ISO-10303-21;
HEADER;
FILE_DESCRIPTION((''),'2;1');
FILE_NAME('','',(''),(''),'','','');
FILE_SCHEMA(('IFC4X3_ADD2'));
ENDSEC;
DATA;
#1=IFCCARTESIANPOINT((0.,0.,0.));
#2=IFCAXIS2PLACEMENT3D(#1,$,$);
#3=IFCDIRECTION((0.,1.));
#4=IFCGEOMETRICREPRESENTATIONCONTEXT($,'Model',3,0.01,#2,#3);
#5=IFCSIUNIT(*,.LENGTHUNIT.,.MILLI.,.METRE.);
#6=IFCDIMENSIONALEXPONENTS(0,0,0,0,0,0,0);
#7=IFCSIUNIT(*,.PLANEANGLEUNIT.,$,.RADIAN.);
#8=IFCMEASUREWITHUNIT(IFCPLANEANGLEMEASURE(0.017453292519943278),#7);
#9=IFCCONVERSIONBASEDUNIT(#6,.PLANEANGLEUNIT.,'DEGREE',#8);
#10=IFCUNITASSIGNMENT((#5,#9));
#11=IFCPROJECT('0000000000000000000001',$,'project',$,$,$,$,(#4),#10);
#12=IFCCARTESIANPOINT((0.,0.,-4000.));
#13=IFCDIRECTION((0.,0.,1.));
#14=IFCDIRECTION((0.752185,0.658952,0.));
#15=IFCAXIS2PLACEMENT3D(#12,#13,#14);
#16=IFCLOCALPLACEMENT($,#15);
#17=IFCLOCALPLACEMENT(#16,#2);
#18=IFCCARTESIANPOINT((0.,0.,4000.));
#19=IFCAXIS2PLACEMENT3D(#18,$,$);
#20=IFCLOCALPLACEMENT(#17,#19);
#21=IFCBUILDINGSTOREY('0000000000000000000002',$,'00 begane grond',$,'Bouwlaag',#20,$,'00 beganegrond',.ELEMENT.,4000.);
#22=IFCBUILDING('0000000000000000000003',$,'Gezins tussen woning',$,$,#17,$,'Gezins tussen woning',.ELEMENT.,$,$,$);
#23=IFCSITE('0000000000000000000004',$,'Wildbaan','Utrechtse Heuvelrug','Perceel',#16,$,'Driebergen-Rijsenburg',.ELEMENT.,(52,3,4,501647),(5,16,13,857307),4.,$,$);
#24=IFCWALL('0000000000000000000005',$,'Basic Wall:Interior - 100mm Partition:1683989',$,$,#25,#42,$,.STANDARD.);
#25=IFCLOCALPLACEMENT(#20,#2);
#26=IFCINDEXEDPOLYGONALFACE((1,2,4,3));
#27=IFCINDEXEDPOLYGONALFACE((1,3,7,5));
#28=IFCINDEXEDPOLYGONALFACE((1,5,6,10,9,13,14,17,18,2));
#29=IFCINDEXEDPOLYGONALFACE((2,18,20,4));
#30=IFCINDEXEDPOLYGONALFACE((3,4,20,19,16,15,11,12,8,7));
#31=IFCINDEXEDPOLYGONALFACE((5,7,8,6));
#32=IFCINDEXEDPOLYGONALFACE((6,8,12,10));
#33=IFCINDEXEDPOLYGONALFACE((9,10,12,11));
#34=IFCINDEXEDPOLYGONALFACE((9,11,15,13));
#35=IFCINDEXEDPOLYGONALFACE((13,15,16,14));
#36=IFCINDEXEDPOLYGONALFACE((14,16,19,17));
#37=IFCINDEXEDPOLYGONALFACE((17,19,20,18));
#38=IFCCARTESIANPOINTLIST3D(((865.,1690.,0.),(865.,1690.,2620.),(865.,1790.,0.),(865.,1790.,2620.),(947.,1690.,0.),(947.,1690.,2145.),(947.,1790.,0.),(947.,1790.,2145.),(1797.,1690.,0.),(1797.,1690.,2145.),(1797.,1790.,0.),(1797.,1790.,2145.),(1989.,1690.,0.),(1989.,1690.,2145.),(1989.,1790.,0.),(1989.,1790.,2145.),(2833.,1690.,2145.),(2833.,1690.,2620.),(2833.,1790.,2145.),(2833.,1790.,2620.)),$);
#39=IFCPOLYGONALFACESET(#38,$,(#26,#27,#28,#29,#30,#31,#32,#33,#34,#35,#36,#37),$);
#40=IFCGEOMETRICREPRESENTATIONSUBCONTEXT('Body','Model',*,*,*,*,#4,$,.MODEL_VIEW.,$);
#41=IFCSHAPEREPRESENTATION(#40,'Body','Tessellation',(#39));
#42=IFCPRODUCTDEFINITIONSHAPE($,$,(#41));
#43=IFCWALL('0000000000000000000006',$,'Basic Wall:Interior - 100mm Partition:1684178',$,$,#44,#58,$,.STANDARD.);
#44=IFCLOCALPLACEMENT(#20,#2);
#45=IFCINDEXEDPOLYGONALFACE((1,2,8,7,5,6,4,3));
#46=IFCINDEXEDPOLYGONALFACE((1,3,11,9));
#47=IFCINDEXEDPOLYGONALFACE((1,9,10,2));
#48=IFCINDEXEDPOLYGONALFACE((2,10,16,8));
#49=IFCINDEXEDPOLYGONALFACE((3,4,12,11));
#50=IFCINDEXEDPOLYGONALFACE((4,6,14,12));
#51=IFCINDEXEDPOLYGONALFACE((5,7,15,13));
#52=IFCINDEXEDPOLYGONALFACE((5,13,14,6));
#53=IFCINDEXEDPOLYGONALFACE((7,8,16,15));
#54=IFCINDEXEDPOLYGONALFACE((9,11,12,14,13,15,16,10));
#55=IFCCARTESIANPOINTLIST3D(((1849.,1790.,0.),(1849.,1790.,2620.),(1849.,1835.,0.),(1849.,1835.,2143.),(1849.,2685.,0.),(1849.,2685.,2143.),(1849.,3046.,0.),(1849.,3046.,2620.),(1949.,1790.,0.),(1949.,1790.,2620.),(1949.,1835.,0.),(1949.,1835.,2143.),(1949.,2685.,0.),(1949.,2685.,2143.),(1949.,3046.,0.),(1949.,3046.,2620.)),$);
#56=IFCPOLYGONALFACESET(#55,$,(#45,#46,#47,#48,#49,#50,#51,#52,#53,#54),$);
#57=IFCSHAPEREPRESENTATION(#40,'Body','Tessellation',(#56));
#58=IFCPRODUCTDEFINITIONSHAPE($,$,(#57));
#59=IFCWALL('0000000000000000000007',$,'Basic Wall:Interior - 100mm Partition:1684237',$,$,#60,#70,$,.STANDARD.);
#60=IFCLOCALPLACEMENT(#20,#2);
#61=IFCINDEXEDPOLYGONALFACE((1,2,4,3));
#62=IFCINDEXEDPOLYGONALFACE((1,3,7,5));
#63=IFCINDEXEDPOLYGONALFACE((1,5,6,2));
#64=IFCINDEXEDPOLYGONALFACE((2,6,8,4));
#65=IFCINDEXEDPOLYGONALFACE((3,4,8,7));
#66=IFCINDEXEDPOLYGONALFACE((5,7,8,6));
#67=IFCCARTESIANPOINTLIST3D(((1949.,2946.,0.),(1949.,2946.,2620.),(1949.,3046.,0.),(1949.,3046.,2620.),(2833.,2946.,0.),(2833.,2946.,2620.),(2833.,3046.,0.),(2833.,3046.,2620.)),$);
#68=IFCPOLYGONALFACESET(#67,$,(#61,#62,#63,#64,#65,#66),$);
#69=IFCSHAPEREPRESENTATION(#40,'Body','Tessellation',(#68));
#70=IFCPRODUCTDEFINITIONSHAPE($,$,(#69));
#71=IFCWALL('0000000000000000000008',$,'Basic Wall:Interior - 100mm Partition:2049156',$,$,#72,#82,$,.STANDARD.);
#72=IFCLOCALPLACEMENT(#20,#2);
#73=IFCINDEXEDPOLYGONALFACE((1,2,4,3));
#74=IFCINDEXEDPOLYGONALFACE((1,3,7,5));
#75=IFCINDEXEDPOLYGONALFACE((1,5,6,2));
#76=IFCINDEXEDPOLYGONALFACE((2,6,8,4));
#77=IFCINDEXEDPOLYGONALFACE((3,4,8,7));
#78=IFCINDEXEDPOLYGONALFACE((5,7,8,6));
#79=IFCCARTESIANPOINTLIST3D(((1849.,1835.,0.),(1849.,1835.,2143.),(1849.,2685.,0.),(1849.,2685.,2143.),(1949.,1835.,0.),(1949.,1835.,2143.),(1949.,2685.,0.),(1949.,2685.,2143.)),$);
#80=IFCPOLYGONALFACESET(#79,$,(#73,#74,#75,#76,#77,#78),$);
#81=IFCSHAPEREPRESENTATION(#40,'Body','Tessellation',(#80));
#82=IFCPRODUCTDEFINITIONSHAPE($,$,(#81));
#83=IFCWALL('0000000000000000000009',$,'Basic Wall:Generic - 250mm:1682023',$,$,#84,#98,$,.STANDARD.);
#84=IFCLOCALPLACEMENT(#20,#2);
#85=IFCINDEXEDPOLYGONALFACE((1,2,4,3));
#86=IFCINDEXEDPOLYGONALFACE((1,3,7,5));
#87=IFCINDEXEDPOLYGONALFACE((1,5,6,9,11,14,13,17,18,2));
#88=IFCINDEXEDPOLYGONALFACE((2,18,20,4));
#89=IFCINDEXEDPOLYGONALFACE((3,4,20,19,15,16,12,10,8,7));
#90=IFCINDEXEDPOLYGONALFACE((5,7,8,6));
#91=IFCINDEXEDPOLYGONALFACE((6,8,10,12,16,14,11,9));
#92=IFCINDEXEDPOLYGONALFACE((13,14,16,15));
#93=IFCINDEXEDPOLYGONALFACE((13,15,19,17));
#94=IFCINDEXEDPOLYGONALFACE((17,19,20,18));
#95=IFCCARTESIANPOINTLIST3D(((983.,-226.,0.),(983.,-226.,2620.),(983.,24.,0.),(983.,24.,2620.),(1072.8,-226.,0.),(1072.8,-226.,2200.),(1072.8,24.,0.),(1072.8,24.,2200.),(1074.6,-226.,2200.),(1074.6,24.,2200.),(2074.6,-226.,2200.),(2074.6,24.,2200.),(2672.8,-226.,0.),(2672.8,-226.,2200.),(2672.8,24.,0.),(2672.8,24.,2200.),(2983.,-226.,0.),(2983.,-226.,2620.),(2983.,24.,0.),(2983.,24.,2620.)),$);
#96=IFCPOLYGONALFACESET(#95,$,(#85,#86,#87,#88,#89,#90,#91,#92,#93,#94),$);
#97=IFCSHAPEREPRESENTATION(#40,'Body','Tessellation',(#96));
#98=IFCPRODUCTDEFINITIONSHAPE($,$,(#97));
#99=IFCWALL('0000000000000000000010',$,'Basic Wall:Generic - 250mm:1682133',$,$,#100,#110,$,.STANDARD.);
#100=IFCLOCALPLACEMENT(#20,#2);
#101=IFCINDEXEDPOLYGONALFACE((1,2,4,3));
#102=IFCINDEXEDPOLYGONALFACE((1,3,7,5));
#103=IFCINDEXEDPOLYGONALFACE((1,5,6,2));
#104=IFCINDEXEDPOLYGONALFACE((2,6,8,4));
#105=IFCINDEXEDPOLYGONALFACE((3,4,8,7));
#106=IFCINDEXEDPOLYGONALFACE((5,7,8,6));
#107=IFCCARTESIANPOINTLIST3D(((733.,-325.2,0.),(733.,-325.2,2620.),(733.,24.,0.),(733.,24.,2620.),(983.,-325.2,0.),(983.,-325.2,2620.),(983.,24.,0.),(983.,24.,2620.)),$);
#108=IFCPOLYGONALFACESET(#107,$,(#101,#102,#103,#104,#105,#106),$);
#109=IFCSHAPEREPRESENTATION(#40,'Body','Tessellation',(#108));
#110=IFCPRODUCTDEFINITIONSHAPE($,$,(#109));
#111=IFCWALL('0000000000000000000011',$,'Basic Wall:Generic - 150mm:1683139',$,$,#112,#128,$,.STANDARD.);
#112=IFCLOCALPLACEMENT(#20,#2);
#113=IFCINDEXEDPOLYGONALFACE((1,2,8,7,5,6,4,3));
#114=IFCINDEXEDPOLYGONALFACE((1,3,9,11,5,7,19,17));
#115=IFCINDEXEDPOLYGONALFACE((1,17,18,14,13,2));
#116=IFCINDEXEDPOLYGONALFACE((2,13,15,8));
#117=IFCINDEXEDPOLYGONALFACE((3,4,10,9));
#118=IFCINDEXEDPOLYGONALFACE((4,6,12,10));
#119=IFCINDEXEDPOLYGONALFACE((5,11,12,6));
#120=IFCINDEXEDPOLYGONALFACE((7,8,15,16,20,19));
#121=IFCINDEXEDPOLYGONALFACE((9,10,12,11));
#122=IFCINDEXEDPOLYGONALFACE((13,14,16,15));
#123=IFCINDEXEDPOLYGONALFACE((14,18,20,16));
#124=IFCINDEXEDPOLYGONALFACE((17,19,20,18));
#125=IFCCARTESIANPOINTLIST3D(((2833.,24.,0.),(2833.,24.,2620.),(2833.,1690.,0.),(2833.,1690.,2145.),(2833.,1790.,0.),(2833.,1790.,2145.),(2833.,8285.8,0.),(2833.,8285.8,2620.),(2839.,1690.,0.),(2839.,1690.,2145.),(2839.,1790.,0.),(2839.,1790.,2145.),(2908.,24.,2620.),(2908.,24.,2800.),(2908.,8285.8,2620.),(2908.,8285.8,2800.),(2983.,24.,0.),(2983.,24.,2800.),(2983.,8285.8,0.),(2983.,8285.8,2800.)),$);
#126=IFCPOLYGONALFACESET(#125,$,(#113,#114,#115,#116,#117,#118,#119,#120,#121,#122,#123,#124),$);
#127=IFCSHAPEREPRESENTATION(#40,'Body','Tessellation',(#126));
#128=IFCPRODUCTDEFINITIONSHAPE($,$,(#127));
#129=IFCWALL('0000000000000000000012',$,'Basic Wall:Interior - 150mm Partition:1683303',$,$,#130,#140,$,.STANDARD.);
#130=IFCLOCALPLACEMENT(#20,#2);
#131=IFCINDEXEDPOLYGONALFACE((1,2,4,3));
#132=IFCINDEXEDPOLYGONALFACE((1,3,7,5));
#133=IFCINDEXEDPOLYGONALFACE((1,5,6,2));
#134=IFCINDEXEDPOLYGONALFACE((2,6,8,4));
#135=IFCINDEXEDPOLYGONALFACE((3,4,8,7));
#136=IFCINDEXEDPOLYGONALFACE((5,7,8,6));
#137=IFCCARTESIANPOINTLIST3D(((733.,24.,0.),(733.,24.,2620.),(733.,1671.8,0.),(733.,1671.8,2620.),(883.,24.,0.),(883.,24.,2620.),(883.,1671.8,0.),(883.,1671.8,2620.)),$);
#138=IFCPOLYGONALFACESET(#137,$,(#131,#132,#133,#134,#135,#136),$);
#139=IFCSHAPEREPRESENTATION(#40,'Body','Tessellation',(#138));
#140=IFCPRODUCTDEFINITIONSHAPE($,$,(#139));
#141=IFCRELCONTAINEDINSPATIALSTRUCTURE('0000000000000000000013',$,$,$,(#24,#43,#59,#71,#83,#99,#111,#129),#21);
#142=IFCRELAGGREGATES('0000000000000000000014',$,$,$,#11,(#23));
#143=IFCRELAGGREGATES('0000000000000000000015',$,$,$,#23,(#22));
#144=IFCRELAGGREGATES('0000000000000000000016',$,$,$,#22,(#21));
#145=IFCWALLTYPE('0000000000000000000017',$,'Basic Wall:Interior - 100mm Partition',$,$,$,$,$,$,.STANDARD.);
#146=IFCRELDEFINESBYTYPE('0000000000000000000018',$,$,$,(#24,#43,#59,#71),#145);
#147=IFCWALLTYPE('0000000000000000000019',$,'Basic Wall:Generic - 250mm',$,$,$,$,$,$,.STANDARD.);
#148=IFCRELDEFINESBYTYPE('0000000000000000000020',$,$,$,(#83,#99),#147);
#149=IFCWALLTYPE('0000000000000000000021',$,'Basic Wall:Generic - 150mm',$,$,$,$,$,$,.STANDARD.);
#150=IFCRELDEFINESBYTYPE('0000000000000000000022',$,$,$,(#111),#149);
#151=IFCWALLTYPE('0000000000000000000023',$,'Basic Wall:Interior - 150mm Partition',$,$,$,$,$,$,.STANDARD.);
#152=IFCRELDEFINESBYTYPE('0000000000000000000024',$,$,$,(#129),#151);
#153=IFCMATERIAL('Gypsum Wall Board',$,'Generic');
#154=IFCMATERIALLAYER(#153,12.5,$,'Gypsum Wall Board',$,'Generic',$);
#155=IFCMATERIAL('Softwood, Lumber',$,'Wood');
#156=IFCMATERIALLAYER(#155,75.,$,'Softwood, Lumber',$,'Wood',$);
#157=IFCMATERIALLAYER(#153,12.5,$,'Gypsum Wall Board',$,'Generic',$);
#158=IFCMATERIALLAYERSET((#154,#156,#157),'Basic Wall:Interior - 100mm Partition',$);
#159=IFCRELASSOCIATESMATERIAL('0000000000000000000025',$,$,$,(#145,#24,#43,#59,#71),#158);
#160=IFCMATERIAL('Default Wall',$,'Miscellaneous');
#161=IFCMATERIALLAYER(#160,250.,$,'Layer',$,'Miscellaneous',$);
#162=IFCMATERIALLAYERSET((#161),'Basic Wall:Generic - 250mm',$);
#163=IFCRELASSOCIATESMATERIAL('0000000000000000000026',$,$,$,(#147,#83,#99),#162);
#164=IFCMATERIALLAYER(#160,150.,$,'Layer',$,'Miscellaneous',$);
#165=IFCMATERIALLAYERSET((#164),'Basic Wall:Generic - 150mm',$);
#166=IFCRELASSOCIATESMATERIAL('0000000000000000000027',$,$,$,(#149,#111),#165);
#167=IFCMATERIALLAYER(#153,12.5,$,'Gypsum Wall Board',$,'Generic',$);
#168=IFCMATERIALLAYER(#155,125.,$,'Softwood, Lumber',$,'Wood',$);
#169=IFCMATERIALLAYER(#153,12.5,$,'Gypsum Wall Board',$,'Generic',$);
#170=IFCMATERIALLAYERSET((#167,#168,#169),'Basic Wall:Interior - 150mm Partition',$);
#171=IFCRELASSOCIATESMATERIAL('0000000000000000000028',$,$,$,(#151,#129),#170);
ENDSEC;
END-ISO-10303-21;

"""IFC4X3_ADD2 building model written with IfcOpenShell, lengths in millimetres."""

from ifc_helpers import new_model, entity, si_unit, converted_unit, direction, frame, frame_2d, origin, place, context, subcontext, project, spatial, polyline, rectangle, extrude, clip, bounded_halfspace, material, layer, layer_set, type_object, element, save


model = new_model("IFC4X3_ADD2")

# Units and contexts
model_context = context("Model", 3, precision=0.01, world=origin(), true_north=direction((0.0, 1.0)))
body_context = subcontext(model_context, "Body", "Model", "MODEL_VIEW")
ifc_project = project(units=[si_unit("LENGTHUNIT", "METRE", prefix="MILLI"), converted_unit("PLANEANGLEUNIT", "DEGREE", entity("IfcPlaneAngleMeasure", 0.017453292519943278), si_unit("PLANEANGLEUNIT", "RADIAN"), dimensions=[0, 0, 0, 0, 0, 0, 0])], contexts=[model_context])

# Site, building, storey
site_placement = place(None, frame((0.0, 0.0, -4000.0), z_axis=(0.0, 0.0, 1.0), x_axis=(0.752185, 0.658952, 0.0)))
site = spatial("IfcSite", under=ifc_project, at=site_placement, Name="Wildbaan", Description="Utrechtse Heuvelrug", ObjectType="Perceel", LongName="Driebergen-Rijsenburg", CompositionType="ELEMENT", RefLatitude=(52, 3, 4, 501647), RefLongitude=(5, 16, 13, 857307), RefElevation=4.0)
building_placement = place(site_placement, origin())
building = spatial("IfcBuilding", under=site, at=building_placement, Name="Gezins tussen woning", LongName="Gezins tussen woning", CompositionType="ELEMENT")
storey_placement = place(building_placement, frame((0.0, 0.0, 4000.0)))
storey = spatial("IfcBuildingStorey", under=building, at=storey_placement, Name="00 begane grond", ObjectType="Bouwlaag", LongName="00 beganegrond", CompositionType="ELEMENT", Elevation=4000.0)

# Shared definitions
ifc_material_1 = material(Name="Gypsum Wall Board", Category="Generic")
ifc_layer_1 = layer(ifc_material_1, 12.5, Name="Gypsum Wall Board", Category="Generic")
ifc_material_2 = material(Name="Softwood, Lumber", Category="Wood")
ifc_layer_2 = layer(ifc_material_2, 75.0, Name="Softwood, Lumber", Category="Wood")
ifc_layer_3 = layer(ifc_material_1, 12.5, Name="Gypsum Wall Board", Category="Generic")
ifc_layer_set_1 = layer_set([ifc_layer_1, ifc_layer_2, ifc_layer_3], Name="Basic Wall:Interior - 100mm Partition")
wall_type_1 = type_object("IfcWallType", Name="Basic Wall:Interior - 100mm Partition", PredefinedType="STANDARD", material=ifc_layer_set_1)

# Wall, openings
wall_1_placement = place(storey_placement, frame((2833.0, 1740.0, 0.0), z_axis=(0.0, 0.0, 1.0), x_axis=(-1.0, 0.0, 0.0)))
wall_1 = element("IfcWall", 1, at=wall_1_placement, inside=storey, type_object=wall_type_1, material=ifc_layer_set_1, Name="Basic Wall:Interior - 100mm Partition:1683989", PredefinedType="STANDARD", context=body_context, shape_type="Clipping", body=[
    clip(extrude(rectangle(XDim=1968.0, YDim=100.0, at=frame_2d((984.0, 0.0), x_axis=(-1.0, 0.0))), origin(), (0.0, 0.0, 1.0), 2620.0), bounded_halfspace(frame((0.0, -50.0, 2620.0), z_axis=(0.0, 0.0, -1.0), x_axis=(0.0, 1.0, 0.0)), True, frame((0.0, -50.0, 2620.0)), polyline([(0.0, 0.0), (884.0, 0.0), (984.0, 0.0), (1968.0, 0.0), (1968.0, 100.0), (0.0, 100.0), (0.0, 0.0)]))),
])
opening_1_placement = place(wall_1_placement, frame((2833.0, 1740.0, 0.0), z_axis=(0.0, 0.0, 1.0), x_axis=(-1.0, 0.0, 0.0)))
element("IfcOpeningElement", 2, at=opening_1_placement, cuts=wall_1, PredefinedType="OPENING", context=body_context, shape_type="SweptSolid", body=[
    extrude(rectangle(XDim=2145.0, YDim=850.0, at=frame_2d((0.0, 0.0), x_axis=(1.0, 0.0))), frame((1372.0, 1790.0, 1072.5), z_axis=(0.0, -1.0, 0.0), x_axis=(0.0, 0.0, -1.0)), (0.0, 0.0, 1.0), 100.0),
])
opening_2_placement = place(wall_1_placement, frame((2833.0, 1740.0, 0.0), z_axis=(0.0, 0.0, 1.0), x_axis=(-1.0, 0.0, 0.0)))
element("IfcOpeningElement", 3, at=opening_2_placement, cuts=wall_1, PredefinedType="OPENING", context=body_context, shape_type="SweptSolid", body=[
    extrude(rectangle(XDim=2145.0, YDim=850.0, at=frame_2d((0.0, 0.0), x_axis=(0.0, 1.0))), frame((2414.0, 1790.0, 1072.5), z_axis=(0.0, -1.0, 0.0), x_axis=(-1.0, 0.0, 0.0)), (0.0, 0.0, 1.0), 100.0),
])

# Wall, opening
wall_2_placement = place(storey_placement, frame((1899.0, 1790.0, 0.0), z_axis=(0.0, 0.0, 1.0), x_axis=(0.0, 1.0, 0.0)))
wall_2 = element("IfcWall", 4, at=wall_2_placement, inside=storey, type_object=wall_type_1, material=ifc_layer_set_1, Name="Basic Wall:Interior - 100mm Partition:1684178", PredefinedType="STANDARD", context=body_context, shape_type="Clipping", body=[
    clip(extrude(rectangle(XDim=1256.0, YDim=100.0, at=frame_2d((628.0, 0.0), x_axis=(1.0, 0.0))), origin(), (0.0, 0.0, 1.0), 2620.0), bounded_halfspace(frame((0.0, -50.0, 2620.0), z_axis=(0.0, 0.0, -1.0), x_axis=(-1.0, 0.0, 0.0)), True, frame((0.0, -50.0, 2620.0)), polyline([(0.0, 0.0), (1156.0, 0.0), (1256.0, 0.0), (1256.0, 100.0), (0.0, 100.0), (0.0, 0.0)]))),
])
opening_3_placement = place(wall_2_placement, frame((-1790.0, 1899.0, -2.0), z_axis=(0.0, 0.0, 1.0), x_axis=(0.0, -1.0, 0.0)))
element("IfcOpeningElement", 5, at=opening_3_placement, cuts=wall_2, PredefinedType="OPENING", context=body_context, shape_type="SweptSolid", body=[
    extrude(rectangle(XDim=2145.0, YDim=850.0, at=frame_2d((0.0, 0.0), x_axis=(0.0, 1.0))), frame((1949.0, 2260.0, 1072.5), z_axis=(-1.0, 0.0, 0.0), x_axis=(0.0, 1.0, 0.0)), (0.0, 0.0, 1.0), 100.0),
])

# Walls
wall_3_placement = place(storey_placement, frame((1949.0, 2996.0, 0.0)))
element("IfcWall", 6, at=wall_3_placement, inside=storey, type_object=wall_type_1, material=ifc_layer_set_1, Name="Basic Wall:Interior - 100mm Partition:1684237", PredefinedType="STANDARD", context=body_context, shape_type="Clipping", body=[
    clip(extrude(rectangle(XDim=884.0, YDim=100.0, at=frame_2d((442.0, 0.0), x_axis=(-1.0, 0.0))), origin(), (0.0, 0.0, 1.0), 2620.0), bounded_halfspace(frame((0.0, -50.0, 2620.0), z_axis=(0.0, 0.0, -1.0), x_axis=(0.0, -1.0, 0.0)), True, frame((0.0, -50.0, 2620.0)), polyline([(0.0, 0.0), (654.0, 0.0), (754.0, 0.0), (884.0, 0.0), (884.0, 100.0), (0.0, 100.0), (0.0, 0.0)]))),
])
wall_4_placement = place(storey_placement, frame((1899.0, 1835.0, 0.0), z_axis=(0.0, 0.0, 1.0), x_axis=(0.0, 1.0, 0.0)))
element("IfcWall", 7, at=wall_4_placement, inside=storey, type_object=wall_type_1, material=ifc_layer_set_1, Name="Basic Wall:Interior - 100mm Partition:2049156", PredefinedType="STANDARD", context=body_context, shape_type="SweptSolid", body=[
    extrude(rectangle(XDim=850.0, YDim=100.0, at=frame_2d((425.0, 0.0), x_axis=(-1.0, 0.0))), origin(), (0.0, 0.0, 1.0), 2143.0),
])

# Wall, openings
ifc_material_3 = material(Name="Default Wall", Category="Miscellaneous")
ifc_layer_4 = layer(ifc_material_3, 250.0, Name="Layer", Category="Miscellaneous")
ifc_layer_set_2 = layer_set([ifc_layer_4], Name="Basic Wall:Generic - 250mm")
wall_type_2 = type_object("IfcWallType", Name="Basic Wall:Generic - 250mm", PredefinedType="STANDARD", material=ifc_layer_set_2)
wall_5_placement = place(storey_placement, frame((983.0, -101.0, 0.0)))
wall_5 = element("IfcWall", 8, at=wall_5_placement, inside=storey, type_object=wall_type_2, material=ifc_layer_set_2, Name="Basic Wall:Generic - 250mm:1682023", PredefinedType="STANDARD", context=body_context, shape_type="SweptSolid", body=[
    extrude(rectangle(XDim=2000.0, YDim=250.0, at=frame_2d((1000.0, 0.0), x_axis=(-1.0, 0.0))), origin(), (0.0, 0.0, 1.0), 2620.0),
])
opening_4_placement = place(wall_5_placement, frame((91.6, -125.0, 0.0)))
element("IfcOpeningElement", 9, at=opening_4_placement, cuts=wall_5, PredefinedType="OPENING", context=body_context, shape_type="SweptSolid", body=[
    extrude(rectangle(XDim=2200.0, YDim=1000.0, at=frame_2d((1100.0, 500.0), x_axis=(1.0, 0.0))), frame((0.0, 0.0, 0.0), z_axis=(0.0, 1.0, 0.0), x_axis=(0.0, 0.0, 1.0)), (0.0, 0.0, 1.0), 250.0),
])
opening_5_placement = place(wall_5_placement, frame((-983.0, 101.0, 0.0)))
element("IfcOpeningElement", 10, at=opening_5_placement, cuts=wall_5, PredefinedType="OPENING", context=body_context, shape_type="SweptSolid", body=[
    extrude(rectangle(XDim=2200.0, YDim=1600.0, at=frame_2d((0.0, 0.0), x_axis=(1.0, 0.0))), frame((1872.8, -226.0, 1100.0), z_axis=(0.0, 1.0, 0.0), x_axis=(0.0, 0.0, -1.0)), (0.0, 0.0, 1.0), 250.0),
])

# Wall
wall_6_placement = place(storey_placement, frame((858.0, -325.2, 0.0), z_axis=(0.0, 0.0, 1.0), x_axis=(0.0, 1.0, 0.0)))
element("IfcWall", 11, at=wall_6_placement, inside=storey, type_object=wall_type_2, material=ifc_layer_set_2, Name="Basic Wall:Generic - 250mm:1682133", PredefinedType="STANDARD", context=body_context, shape_type="Clipping", body=[
    clip(extrude(rectangle(XDim=349.2, YDim=250.0, at=frame_2d((174.6, 0.0), x_axis=(-1.0, 0.0))), origin(), (0.0, 0.0, 1.0), 2620.0), bounded_halfspace(frame((0.0, -125.0, 2620.0), z_axis=(0.0, 0.0, -1.0), x_axis=(-1.0, 0.0, 0.0)), True, frame((0.0, -125.0, 2620.0)), polyline([(0.0, 0.0), (99.2, 0.0), (349.2, 0.0), (349.2, 200.0), (0.0, 200.0), (0.0, 0.0)]))),
])

# Wall, opening
ifc_layer_5 = layer(ifc_material_3, 150.0, Name="Layer", Category="Miscellaneous")
ifc_layer_set_3 = layer_set([ifc_layer_5], Name="Basic Wall:Generic - 150mm")
wall_type_3 = type_object("IfcWallType", Name="Basic Wall:Generic - 150mm", PredefinedType="STANDARD", material=ifc_layer_set_3)
wall_7_placement = place(storey_placement, frame((2908.0, 24.0, 0.0), z_axis=(0.0, 0.0, 1.0), x_axis=(0.0, 1.0, 0.0)))
wall_7 = element("IfcWall", 12, at=wall_7_placement, inside=storey, type_object=wall_type_3, material=ifc_layer_set_3, Name="Basic Wall:Generic - 150mm:1683139", PredefinedType="STANDARD", context=body_context, shape_type="Clipping", body=[
    clip(extrude(rectangle(XDim=8261.8, YDim=150.0, at=frame_2d((4130.9, 0.0), x_axis=(-1.0, 0.0))), origin(), (0.0, 0.0, 1.0), 2800.0), bounded_halfspace(frame((8261.8, 75.0, 2620.0), z_axis=(0.0, 0.0, -1.0), x_axis=(-1.0, 0.0, 0.0)), True, frame((8261.8, 75.0, 2620.0)), polyline([(0.0, 0.0), (-8261.8, 0.0), (-8261.8, -75.0), (0.0, -75.0), (0.0, 0.0)]))),
])
opening_6_placement = place(wall_7_placement, frame((-24.0, 2908.0, 0.0)))
element("IfcOpeningElement", 13, at=opening_6_placement, cuts=wall_7, PredefinedType="OPENING", context=body_context, shape_type="SweptSolid", body=[
    extrude(rectangle(XDim=2145.0, YDim=100.0, at=frame_2d((0.0, 0.0), x_axis=(0.0, 1.0))), frame((1740.0, -2839.0, 1072.5), z_axis=(0.0, 1.0, 0.0), x_axis=(1.0, 0.0, 0.0)), (0.0, 0.0, 1.0), 850.0),
])

# Wall
ifc_layer_6 = layer(ifc_material_1, 12.5, Name="Gypsum Wall Board", Category="Generic")
ifc_layer_7 = layer(ifc_material_2, 125.0, Name="Softwood, Lumber", Category="Wood")
ifc_layer_8 = layer(ifc_material_1, 12.5, Name="Gypsum Wall Board", Category="Generic")
ifc_layer_set_4 = layer_set([ifc_layer_6, ifc_layer_7, ifc_layer_8], Name="Basic Wall:Interior - 150mm Partition")
wall_type_4 = type_object("IfcWallType", Name="Basic Wall:Interior - 150mm Partition", PredefinedType="STANDARD", material=ifc_layer_set_4)
wall_8_placement = place(storey_placement, frame((808.0, 24.0, 0.0), z_axis=(0.0, 0.0, 1.0), x_axis=(0.0, 1.0, 0.0)))
element("IfcWall", 14, at=wall_8_placement, inside=storey, type_object=wall_type_4, material=ifc_layer_set_4, Name="Basic Wall:Interior - 150mm Partition:1683303", PredefinedType="STANDARD", context=body_context, shape_type="Clipping", body=[
    clip(clip(extrude(rectangle(XDim=1647.8, YDim=150.0, at=frame_2d((823.9, 0.0), x_axis=(-1.0, 0.0))), origin(), (0.0, 0.0, 1.0), 2620.0), bounded_halfspace(frame((0.0, -75.0, 2620.0), z_axis=(0.0, 0.0, -1.0), x_axis=(-1.0, 0.0, 0.0)), True, frame((0.0, -75.0, 2620.0)), polyline([(0.0, 0.0), (1647.8, 0.0), (1647.8, 100.0), (0.0, 100.0), (0.0, 0.0)]))), bounded_halfspace(frame((1647.8, 25.0, 2620.0), z_axis=(0.0, 0.0, -1.0), x_axis=(-1.0, 0.0, 0.0)), True, frame((1647.8, 25.0, 2620.0)), polyline([(0.0, 0.0), (0.0, 50.0), (-1647.8, 50.0), (-1647.8, 0.0), (0.0, 0.0)]))),
])

save(model, "model.ifc")
